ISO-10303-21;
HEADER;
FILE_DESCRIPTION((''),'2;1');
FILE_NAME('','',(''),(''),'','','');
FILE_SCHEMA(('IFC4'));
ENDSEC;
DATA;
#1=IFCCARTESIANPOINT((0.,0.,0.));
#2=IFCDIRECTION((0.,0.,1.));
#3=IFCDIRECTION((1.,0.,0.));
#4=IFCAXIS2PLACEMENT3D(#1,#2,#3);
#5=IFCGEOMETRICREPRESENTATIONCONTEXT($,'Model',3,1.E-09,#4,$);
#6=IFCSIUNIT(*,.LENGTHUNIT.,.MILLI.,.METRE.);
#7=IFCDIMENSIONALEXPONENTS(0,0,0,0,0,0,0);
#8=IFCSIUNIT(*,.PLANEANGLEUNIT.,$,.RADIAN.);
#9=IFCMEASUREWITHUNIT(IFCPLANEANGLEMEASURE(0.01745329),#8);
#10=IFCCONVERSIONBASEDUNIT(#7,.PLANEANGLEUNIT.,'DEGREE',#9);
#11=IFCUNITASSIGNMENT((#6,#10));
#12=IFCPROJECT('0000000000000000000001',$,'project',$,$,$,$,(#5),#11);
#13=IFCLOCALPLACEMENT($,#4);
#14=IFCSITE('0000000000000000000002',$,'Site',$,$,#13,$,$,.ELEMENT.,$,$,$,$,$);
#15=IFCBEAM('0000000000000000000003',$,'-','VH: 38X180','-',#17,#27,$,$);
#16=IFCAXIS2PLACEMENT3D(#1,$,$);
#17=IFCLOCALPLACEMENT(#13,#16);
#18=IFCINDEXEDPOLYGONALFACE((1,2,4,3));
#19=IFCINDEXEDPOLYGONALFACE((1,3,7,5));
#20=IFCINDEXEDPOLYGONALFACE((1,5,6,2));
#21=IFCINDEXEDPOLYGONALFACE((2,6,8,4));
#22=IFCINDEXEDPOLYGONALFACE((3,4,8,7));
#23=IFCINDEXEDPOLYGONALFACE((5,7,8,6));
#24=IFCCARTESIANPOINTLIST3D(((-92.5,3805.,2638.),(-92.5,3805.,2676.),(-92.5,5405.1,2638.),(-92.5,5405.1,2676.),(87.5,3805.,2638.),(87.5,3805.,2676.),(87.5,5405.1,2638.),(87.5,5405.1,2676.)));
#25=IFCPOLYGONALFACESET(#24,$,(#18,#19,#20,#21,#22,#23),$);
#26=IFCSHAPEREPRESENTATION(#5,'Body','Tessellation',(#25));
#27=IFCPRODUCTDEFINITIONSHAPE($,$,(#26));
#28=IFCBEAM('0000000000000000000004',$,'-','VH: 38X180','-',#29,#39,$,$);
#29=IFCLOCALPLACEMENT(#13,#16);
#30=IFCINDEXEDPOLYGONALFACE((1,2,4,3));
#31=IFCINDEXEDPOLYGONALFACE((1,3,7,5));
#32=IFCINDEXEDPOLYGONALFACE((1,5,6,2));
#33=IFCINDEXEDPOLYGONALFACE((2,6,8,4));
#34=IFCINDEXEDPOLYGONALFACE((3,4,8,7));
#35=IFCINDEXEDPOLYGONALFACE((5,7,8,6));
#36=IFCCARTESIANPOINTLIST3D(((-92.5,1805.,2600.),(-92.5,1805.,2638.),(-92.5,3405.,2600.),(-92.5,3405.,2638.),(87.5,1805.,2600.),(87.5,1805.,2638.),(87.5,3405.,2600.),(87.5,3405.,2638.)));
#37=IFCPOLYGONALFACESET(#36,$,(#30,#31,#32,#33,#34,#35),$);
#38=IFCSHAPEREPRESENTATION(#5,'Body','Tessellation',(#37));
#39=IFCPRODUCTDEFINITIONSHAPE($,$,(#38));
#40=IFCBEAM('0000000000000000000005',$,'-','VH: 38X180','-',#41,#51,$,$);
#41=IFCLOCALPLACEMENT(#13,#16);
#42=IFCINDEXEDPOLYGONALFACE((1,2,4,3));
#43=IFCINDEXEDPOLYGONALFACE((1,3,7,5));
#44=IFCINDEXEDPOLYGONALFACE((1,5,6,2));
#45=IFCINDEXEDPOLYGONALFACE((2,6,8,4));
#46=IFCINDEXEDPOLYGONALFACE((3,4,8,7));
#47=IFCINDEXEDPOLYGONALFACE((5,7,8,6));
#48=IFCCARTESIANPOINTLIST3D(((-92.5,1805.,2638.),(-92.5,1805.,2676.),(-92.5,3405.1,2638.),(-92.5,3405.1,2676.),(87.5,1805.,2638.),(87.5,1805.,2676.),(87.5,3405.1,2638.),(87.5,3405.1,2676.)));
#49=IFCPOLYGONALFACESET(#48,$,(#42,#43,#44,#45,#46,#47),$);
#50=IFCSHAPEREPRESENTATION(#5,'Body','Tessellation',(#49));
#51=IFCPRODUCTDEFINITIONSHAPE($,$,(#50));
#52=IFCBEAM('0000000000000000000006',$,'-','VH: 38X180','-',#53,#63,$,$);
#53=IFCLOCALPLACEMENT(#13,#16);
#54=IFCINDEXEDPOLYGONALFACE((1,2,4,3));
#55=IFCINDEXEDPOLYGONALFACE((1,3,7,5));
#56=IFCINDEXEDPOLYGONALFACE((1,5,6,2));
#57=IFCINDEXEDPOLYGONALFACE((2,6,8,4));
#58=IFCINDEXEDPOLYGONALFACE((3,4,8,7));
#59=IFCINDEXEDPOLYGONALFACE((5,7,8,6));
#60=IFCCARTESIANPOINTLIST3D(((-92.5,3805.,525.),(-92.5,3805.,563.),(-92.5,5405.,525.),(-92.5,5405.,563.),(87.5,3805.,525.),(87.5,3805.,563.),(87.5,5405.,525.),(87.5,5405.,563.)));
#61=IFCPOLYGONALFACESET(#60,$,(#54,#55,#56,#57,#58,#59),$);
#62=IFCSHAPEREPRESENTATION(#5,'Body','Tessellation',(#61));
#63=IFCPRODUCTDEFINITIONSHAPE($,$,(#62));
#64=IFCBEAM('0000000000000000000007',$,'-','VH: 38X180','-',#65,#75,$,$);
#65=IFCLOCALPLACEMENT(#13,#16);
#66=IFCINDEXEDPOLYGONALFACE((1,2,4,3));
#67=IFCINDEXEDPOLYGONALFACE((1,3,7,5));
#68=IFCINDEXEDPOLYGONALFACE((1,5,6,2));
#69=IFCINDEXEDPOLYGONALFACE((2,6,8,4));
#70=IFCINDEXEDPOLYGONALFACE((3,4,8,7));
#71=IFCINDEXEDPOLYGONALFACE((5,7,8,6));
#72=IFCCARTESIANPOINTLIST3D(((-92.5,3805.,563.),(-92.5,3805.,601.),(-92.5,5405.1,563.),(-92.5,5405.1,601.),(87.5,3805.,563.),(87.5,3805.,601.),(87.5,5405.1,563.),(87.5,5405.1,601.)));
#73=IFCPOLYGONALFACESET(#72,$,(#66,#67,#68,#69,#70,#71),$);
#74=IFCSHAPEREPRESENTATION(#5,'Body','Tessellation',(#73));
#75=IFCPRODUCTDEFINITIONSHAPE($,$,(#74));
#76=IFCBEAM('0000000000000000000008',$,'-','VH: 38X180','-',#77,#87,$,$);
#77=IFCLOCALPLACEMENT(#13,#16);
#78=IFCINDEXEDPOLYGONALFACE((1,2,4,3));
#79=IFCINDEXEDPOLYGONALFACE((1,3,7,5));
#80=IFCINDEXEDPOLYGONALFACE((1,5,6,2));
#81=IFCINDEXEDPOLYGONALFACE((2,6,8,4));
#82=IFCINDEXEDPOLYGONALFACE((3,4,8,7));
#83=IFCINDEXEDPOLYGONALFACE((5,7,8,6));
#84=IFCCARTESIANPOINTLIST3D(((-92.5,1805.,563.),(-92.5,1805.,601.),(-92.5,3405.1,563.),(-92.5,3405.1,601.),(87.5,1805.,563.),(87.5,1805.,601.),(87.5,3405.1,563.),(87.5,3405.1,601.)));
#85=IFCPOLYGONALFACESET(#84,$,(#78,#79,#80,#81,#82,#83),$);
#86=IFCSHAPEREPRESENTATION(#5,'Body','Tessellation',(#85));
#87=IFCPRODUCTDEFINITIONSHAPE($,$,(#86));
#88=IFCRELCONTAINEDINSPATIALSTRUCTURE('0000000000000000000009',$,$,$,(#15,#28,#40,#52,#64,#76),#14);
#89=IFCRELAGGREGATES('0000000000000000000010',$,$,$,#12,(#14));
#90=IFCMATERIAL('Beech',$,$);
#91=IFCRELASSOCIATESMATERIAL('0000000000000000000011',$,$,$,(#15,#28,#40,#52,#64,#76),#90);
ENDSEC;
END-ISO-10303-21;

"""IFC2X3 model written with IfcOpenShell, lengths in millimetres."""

from ifc_helpers import new_model, entity, si_unit, converted_unit, frame, origin, origin_with_axes, origin_2d, place, context, project, spatial, rectangle, extrude, material, element, save


model = new_model("IFC2X3")

# Units and contexts
model_context = context("Model", 3, precision=1e-09, world=origin_with_axes())
ifc_project = project(units=[si_unit("LENGTHUNIT", "METRE", prefix="MILLI"), converted_unit("PLANEANGLEUNIT", "DEGREE", entity("IfcPlaneAngleMeasure", 0.01745329), si_unit("PLANEANGLEUNIT", "RADIAN"), dimensions=[0, 0, 0, 0, 0, 0, 0])], contexts=[model_context])

# Site
site_placement = place(None, origin_with_axes())
site = spatial("IfcSite", under=ifc_project, at=site_placement, Name="Site", CompositionType="ELEMENT")

# Shared definitions
ifc_material = material(Name="Beech")

# Beams
beam_1_placement = place(None, frame((-2.5, 5405.1, 2657.0), z_axis=(0.0, -1.0, 0.0), x_axis=(0.0, 0.0, 1.0)))
element("IfcBeam", 1, at=beam_1_placement, inside=site, material=ifc_material, Name="-", Description="VH: 38X180", ObjectType="-", context=model_context, shape_type="SweptSolid", body=[
    extrude(rectangle(XDim=38.0, YDim=180.0, at=origin_2d()), origin(), (0.0, 0.0, 1.0), 1600.1),
])
beam_2_placement = place(None, frame((-2.5, 3405.0, 2619.0), z_axis=(0.0, -1.0, 0.0), x_axis=(0.0, 0.0, 1.0)))
element("IfcBeam", 2, at=beam_2_placement, inside=site, material=ifc_material, Name="-", Description="VH: 38X180", ObjectType="-", context=model_context, shape_type="SweptSolid", body=[
    extrude(rectangle(XDim=38.0, YDim=180.0, at=origin_2d()), origin(), (0.0, 0.0, 1.0), 1600.0),
])
beam_3_placement = place(None, frame((-2.5, 3405.1, 2657.0), z_axis=(0.0, -1.0, 0.0), x_axis=(0.0, 0.0, 1.0)))
element("IfcBeam", 3, at=beam_3_placement, inside=site, material=ifc_material, Name="-", Description="VH: 38X180", ObjectType="-", context=model_context, shape_type="SweptSolid", body=[
    extrude(rectangle(XDim=38.0, YDim=180.0, at=origin_2d()), origin(), (0.0, 0.0, 1.0), 1600.1),
])
beam_4_placement = place(None, frame((-2.5, 5405.0, 544.0), z_axis=(0.0, -1.0, 0.0), x_axis=(0.0, 0.0, 1.0)))
element("IfcBeam", 4, at=beam_4_placement, inside=site, material=ifc_material, Name="-", Description="VH: 38X180", ObjectType="-", context=model_context, shape_type="SweptSolid", body=[
    extrude(rectangle(XDim=38.0, YDim=180.0, at=origin_2d()), origin(), (0.0, 0.0, 1.0), 1600.0),
])
for number, where, z_axis, x_axis, name in (
    (5, (-2.5, 5405.1, 582.0), (0.0, -1.0, 0.0), (0.0, 0.0, 1.0), "-"),
    (6, (-2.5, 3405.1, 582.0), (0.0, -1.0, 0.0), (0.0, 0.0, 1.0), "-"),
):
    element("IfcBeam", number, at=place(None, frame(where, z_axis=z_axis, x_axis=x_axis)), inside=site, material=ifc_material, Name=name, Description="VH: 38X180", ObjectType="-", context=model_context, shape_type="SweptSolid", body=[
        extrude(rectangle(XDim=38.0, YDim=180.0, at=origin_2d()), origin(), (0.0, 0.0, 1.0), 1600.1),
    ])

save(model, "model.ifc")
